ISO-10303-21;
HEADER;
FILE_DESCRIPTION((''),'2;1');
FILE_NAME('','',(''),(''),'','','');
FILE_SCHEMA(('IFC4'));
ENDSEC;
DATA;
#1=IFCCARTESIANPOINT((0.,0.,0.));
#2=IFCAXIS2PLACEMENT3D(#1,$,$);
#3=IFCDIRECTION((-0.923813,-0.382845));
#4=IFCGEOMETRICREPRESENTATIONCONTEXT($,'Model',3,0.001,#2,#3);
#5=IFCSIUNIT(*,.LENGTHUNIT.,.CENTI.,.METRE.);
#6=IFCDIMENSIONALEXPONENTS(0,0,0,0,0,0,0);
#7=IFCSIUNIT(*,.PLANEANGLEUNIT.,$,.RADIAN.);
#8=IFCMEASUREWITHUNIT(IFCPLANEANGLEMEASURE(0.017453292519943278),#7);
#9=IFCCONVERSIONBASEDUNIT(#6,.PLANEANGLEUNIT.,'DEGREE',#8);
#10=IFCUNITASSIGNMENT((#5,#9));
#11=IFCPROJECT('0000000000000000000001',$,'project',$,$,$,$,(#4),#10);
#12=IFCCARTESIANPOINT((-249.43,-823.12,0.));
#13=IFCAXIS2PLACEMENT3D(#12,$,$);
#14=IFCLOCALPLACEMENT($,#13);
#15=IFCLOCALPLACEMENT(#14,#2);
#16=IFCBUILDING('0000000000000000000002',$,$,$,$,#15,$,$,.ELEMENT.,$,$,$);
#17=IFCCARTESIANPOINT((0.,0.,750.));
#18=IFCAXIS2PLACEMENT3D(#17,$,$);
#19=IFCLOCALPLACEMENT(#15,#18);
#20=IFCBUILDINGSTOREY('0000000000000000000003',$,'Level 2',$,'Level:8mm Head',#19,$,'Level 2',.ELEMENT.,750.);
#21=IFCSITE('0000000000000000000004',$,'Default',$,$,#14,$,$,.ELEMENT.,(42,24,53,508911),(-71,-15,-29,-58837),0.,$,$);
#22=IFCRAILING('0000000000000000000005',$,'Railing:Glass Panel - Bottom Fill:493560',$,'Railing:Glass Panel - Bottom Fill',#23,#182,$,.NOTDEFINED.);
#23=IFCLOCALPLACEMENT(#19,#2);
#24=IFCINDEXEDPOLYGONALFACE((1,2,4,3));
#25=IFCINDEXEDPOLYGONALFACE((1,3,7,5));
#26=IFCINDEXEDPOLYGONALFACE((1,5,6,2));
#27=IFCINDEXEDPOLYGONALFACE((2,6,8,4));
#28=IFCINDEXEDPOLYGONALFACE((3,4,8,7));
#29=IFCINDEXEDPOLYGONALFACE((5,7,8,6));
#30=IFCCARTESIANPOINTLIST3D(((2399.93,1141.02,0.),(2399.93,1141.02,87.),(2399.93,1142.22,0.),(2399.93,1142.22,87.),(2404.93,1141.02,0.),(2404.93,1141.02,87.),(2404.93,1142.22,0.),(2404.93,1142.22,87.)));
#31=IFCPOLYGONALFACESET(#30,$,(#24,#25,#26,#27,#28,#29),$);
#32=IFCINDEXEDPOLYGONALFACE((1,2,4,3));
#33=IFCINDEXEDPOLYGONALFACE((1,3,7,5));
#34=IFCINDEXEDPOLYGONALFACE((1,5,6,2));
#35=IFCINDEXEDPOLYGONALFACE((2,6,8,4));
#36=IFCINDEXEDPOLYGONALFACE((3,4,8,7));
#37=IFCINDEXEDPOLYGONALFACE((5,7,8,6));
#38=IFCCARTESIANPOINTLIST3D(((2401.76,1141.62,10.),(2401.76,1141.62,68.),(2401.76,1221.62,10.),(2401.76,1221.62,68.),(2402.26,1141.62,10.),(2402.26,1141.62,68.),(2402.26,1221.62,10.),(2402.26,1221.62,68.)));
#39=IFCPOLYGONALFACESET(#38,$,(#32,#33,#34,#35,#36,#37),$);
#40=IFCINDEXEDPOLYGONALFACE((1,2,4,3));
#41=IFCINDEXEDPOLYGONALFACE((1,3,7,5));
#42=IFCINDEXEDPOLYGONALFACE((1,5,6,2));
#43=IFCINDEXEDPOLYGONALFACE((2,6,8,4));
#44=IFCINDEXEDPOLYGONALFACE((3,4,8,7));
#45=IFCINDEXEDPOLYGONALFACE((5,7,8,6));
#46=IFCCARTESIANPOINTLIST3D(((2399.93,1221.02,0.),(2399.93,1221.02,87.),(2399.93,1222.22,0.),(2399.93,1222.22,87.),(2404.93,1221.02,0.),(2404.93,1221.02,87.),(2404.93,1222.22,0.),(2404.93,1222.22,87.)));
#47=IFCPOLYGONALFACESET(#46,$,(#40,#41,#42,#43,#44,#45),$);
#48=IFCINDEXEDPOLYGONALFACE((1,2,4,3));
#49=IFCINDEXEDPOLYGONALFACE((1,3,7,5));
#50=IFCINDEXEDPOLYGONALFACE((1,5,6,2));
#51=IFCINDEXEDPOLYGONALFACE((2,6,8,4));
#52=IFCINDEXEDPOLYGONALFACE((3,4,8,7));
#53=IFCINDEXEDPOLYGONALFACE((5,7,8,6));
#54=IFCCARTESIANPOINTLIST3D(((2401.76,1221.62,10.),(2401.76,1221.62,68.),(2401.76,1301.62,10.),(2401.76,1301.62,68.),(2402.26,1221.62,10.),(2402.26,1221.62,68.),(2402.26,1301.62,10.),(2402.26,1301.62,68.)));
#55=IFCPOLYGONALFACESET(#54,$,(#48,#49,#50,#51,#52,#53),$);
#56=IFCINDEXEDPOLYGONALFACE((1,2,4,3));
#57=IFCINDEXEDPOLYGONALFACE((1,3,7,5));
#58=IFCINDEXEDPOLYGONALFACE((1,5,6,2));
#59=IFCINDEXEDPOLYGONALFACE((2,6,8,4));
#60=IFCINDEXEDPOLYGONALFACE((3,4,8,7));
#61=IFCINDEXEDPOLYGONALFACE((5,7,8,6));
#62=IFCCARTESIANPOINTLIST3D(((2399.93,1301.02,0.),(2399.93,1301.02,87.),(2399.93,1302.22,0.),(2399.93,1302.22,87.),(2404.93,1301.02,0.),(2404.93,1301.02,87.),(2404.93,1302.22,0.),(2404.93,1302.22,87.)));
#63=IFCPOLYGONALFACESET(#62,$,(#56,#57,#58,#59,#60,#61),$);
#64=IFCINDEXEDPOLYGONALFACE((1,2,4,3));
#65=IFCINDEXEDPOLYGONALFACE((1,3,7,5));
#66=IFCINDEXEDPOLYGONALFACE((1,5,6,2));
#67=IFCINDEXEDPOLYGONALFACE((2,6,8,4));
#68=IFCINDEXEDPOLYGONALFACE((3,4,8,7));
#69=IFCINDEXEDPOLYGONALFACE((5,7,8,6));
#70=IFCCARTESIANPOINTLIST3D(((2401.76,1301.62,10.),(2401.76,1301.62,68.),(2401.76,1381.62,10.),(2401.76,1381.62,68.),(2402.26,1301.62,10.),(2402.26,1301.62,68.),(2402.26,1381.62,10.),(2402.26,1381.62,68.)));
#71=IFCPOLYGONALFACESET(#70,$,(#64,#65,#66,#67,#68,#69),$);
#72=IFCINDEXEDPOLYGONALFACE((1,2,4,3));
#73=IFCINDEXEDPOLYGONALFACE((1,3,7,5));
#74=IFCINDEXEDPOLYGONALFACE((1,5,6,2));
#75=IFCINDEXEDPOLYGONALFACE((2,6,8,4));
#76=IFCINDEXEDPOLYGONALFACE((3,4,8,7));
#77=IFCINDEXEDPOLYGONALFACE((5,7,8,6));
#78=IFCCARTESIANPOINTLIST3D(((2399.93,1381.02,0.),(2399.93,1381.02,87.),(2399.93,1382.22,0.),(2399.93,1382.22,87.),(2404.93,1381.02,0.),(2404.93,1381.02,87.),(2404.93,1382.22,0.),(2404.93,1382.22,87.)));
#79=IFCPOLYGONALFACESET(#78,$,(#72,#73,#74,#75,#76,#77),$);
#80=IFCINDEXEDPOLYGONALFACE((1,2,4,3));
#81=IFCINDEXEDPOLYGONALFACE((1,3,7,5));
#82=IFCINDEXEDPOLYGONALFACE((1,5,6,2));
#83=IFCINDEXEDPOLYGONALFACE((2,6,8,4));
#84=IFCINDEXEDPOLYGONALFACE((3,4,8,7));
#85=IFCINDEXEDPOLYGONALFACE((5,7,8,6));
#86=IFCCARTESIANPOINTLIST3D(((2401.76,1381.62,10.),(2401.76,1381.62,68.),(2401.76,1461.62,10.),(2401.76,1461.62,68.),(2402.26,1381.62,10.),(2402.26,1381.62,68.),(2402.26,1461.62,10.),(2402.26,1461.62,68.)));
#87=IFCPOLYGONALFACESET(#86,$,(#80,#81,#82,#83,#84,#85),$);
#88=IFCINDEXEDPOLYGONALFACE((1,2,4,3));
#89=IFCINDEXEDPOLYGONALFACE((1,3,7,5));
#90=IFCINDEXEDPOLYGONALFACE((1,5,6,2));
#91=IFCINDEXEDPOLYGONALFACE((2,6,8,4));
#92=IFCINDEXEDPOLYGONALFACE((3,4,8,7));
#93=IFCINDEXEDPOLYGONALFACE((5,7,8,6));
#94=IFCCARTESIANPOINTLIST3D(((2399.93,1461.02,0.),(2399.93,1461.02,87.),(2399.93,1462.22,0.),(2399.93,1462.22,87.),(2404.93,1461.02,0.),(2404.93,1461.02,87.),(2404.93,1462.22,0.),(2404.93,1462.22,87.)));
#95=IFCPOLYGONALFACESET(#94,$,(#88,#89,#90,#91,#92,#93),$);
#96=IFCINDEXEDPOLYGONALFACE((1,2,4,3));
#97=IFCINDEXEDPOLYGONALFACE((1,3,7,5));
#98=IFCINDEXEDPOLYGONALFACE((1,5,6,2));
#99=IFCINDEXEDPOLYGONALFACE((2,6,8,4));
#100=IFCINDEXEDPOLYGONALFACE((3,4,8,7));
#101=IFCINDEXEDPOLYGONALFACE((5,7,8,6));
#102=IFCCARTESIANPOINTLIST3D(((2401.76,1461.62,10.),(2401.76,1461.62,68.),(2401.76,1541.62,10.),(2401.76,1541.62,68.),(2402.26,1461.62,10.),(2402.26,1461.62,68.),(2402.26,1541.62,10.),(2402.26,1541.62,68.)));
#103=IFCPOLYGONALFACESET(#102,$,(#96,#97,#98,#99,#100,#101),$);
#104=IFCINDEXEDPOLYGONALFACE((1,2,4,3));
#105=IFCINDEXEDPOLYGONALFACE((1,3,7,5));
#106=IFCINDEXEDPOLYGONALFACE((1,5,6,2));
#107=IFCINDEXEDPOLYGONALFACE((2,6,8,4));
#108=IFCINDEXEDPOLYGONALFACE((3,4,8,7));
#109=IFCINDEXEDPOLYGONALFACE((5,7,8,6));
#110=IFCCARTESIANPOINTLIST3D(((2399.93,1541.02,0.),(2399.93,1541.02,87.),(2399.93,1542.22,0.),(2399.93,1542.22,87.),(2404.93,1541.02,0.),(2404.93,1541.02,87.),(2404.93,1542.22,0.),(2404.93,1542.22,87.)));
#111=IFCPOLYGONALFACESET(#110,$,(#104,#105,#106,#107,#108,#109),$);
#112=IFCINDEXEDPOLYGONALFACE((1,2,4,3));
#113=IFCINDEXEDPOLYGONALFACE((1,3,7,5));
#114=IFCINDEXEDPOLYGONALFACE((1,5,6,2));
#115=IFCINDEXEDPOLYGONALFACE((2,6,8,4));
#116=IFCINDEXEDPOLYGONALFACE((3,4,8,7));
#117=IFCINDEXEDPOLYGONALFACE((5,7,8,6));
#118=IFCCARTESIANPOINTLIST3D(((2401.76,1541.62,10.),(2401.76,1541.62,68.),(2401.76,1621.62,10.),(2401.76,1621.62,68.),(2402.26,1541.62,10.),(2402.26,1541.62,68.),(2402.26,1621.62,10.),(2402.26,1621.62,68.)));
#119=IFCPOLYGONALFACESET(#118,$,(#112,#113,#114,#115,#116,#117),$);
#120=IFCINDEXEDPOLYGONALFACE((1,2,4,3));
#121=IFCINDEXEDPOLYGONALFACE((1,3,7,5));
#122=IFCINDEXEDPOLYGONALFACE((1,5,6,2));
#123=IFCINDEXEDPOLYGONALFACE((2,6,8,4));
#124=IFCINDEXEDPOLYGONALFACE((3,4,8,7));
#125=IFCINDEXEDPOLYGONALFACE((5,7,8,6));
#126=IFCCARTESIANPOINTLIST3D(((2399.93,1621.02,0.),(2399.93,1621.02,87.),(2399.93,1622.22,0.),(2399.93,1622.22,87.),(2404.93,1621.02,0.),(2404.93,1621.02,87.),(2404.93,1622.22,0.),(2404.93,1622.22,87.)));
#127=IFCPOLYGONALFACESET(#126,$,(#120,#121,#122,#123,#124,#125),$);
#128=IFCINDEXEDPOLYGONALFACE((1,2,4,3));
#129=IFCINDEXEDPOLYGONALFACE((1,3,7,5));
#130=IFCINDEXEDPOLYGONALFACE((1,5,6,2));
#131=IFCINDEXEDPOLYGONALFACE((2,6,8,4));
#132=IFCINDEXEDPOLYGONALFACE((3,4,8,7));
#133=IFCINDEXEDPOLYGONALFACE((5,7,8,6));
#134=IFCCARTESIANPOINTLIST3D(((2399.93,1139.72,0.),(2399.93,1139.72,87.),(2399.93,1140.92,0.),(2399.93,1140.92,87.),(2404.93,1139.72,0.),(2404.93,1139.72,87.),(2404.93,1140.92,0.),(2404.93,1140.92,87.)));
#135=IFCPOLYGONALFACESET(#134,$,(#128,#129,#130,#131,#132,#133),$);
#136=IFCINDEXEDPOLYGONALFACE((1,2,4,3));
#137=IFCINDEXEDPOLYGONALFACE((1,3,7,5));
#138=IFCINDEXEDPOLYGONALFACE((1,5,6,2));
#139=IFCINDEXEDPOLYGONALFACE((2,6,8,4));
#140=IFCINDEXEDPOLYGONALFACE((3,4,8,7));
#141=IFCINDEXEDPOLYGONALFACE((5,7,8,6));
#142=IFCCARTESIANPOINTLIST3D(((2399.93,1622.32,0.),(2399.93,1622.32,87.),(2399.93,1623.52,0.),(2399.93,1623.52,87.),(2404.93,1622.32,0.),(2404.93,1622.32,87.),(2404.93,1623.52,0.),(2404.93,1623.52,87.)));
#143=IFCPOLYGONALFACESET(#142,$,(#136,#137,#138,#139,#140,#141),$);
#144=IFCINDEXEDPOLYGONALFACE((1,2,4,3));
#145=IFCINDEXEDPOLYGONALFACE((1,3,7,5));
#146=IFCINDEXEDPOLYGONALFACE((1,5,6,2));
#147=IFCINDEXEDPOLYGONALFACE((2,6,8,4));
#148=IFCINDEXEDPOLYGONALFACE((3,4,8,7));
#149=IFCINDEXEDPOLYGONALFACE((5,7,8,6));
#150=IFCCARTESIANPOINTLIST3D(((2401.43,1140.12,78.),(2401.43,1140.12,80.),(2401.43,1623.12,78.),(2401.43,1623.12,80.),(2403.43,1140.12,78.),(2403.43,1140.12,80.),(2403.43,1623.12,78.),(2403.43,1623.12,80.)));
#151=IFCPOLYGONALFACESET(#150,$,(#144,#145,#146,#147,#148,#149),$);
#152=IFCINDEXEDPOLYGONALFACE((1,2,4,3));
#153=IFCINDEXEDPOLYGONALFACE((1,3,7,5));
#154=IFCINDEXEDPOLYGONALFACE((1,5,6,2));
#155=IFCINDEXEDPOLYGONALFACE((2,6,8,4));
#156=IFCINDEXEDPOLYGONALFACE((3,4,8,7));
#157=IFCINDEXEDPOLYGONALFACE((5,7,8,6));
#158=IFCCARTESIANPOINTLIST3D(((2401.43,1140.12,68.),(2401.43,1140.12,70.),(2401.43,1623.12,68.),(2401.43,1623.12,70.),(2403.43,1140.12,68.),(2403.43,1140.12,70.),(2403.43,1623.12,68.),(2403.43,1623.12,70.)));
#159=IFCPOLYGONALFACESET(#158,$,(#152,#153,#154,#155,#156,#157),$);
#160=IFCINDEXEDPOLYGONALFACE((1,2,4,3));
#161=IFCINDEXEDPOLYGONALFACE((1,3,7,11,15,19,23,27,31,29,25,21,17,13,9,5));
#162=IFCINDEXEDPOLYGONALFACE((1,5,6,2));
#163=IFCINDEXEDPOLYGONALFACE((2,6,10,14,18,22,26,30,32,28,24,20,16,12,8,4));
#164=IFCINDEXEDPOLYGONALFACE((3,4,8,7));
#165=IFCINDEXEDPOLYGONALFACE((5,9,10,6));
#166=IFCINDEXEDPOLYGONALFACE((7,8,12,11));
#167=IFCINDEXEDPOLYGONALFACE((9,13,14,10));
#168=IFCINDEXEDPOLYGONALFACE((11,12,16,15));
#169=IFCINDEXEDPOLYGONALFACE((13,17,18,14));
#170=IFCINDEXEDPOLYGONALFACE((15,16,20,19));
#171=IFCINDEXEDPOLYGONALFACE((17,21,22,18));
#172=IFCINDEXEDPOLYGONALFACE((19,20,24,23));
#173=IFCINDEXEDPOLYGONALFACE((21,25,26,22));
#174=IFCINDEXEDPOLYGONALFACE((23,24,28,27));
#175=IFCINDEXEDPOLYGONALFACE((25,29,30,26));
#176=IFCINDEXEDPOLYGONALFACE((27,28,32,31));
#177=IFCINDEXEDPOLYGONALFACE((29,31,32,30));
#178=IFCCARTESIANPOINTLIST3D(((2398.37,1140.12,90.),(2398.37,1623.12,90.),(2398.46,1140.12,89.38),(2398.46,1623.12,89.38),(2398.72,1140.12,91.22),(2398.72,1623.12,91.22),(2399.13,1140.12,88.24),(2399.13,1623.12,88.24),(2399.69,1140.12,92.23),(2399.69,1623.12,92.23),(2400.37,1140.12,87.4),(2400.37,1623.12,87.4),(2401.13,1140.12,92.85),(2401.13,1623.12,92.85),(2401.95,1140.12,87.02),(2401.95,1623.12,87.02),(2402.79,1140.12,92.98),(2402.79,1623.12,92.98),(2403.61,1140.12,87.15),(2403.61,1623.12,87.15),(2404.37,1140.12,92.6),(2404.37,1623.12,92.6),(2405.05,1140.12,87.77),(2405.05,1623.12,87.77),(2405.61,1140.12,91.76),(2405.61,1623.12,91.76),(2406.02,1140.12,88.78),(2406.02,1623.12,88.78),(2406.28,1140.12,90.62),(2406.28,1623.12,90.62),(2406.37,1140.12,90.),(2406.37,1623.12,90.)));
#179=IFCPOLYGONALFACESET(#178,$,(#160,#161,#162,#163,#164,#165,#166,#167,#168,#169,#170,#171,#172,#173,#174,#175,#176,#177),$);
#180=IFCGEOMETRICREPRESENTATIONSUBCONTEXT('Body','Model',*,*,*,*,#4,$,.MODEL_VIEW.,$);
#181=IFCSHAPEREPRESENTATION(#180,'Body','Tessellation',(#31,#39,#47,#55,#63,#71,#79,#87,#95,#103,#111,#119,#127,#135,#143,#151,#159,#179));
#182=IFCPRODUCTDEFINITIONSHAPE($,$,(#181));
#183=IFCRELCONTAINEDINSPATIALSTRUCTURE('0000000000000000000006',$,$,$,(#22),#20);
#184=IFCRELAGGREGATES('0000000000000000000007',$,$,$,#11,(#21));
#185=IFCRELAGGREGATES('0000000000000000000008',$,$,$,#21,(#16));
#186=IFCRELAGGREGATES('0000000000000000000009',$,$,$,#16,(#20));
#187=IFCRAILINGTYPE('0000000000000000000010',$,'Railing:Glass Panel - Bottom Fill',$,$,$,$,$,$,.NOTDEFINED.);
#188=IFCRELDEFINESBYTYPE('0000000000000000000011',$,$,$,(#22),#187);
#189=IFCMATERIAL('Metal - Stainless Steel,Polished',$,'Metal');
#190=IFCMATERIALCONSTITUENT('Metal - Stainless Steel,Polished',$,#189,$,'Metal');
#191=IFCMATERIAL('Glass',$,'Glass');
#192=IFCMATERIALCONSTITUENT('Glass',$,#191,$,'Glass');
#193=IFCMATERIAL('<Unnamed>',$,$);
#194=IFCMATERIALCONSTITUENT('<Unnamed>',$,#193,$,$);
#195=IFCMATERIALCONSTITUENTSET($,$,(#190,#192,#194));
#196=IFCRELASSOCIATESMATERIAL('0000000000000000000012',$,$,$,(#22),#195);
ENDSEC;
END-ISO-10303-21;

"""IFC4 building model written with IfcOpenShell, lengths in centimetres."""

from ifc_helpers import new_model, entity, si_unit, converted_unit, direction, frame, origin, place, context, subcontext, project, spatial, indexed_curve, outline, extrude, material, constituent, constituent_set, type_object, element, save


model = new_model("IFC4")

# Units and contexts
model_context = context("Model", 3, precision=0.001, world=origin(), true_north=direction((-0.923813, -0.382845)))
body_context = subcontext(model_context, "Body", "Model", "MODEL_VIEW")
ifc_project = project(units=[si_unit("LENGTHUNIT", "METRE", prefix="CENTI"), converted_unit("PLANEANGLEUNIT", "DEGREE", entity("IfcPlaneAngleMeasure", 0.017453292519943278), si_unit("PLANEANGLEUNIT", "RADIAN"), dimensions=[0, 0, 0, 0, 0, 0, 0])], contexts=[model_context])

# Site, building, storey
site_placement = place(None, frame((-249.43, -823.12, 0.0)))
site = spatial("IfcSite", under=ifc_project, at=site_placement, Name="Default", CompositionType="ELEMENT", RefLatitude=(42, 24, 53, 508911), RefLongitude=(-71, -15, -29, -58837), RefElevation=0.0)
building_placement = place(site_placement, origin())
building = spatial("IfcBuilding", under=site, at=building_placement, CompositionType="ELEMENT")
storey_placement = place(building_placement, frame((0.0, 0.0, 750.0)))
storey = spatial("IfcBuildingStorey", under=building, at=storey_placement, Name="Level 2", ObjectType="Level:8mm Head", LongName="Level 2", CompositionType="ELEMENT", Elevation=750.0)

# Railing
ifc_material_1 = material(Name="Metal - Stainless Steel,Polished", Category="Metal")
ifc_constituent_1 = constituent(ifc_material_1, Name="Metal - Stainless Steel,Polished", Category="Metal")
ifc_material_2 = material(Name="Glass", Category="Glass")
ifc_constituent_2 = constituent(ifc_material_2, Name="Glass", Category="Glass")
ifc_material_3 = material(Name="<Unnamed>")
ifc_constituent_3 = constituent(ifc_material_3, Name="<Unnamed>")
ifc_constituent_set_1 = constituent_set(constituents=[ifc_constituent_1, ifc_constituent_2, ifc_constituent_3])
railing_type = type_object("IfcRailingType", Name="Railing:Glass Panel - Bottom Fill", PredefinedType="NOTDEFINED")
railing_placement = place(storey_placement, frame((2398.21, 1139.72, 0.0)))
element("IfcRailing", 1, at=railing_placement, inside=storey, type_object=railing_type, material=ifc_constituent_set_1, Name="Railing:Glass Panel - Bottom Fill:493560", ObjectType="Railing:Glass Panel - Bottom Fill", PredefinedType="NOTDEFINED", context=body_context, shape_type="SweptSolid", body=[
    extrude(outline(indexed_curve([(-2.5, -0.6), (2.5, -0.6), (2.5, 0.6), (-2.5, 0.6), (-2.5, -0.6)], self_intersect=False)), frame((4.22, 1.9, 0.0), z_axis=(0.0, 0.0, 1.0), x_axis=(-1.0, 0.0, 0.0)), (0.0, 0.0, 1.0), 87.0),
    extrude(outline(indexed_curve([(-0.25, -40.0), (0.25, -40.0), (0.25, 40.0), (-0.25, 40.0), (-0.25, -40.0)], self_intersect=False)), frame((3.8, 41.9, 10.0), z_axis=(0.0, 0.0, 1.0), x_axis=(-1.0, 0.0, 0.0)), (0.0, 0.0, 1.0), 58.0),
    extrude(outline(indexed_curve([(-2.5, -0.6), (2.5, -0.6), (2.5, 0.6), (-2.5, 0.6), (-2.5, -0.6)], self_intersect=False)), frame((4.22, 81.9, 0.0), z_axis=(0.0, 0.0, 1.0), x_axis=(-1.0, 0.0, 0.0)), (0.0, 0.0, 1.0), 87.0),
    extrude(outline(indexed_curve([(-0.25, -40.0), (0.25, -40.0), (0.25, 40.0), (-0.25, 40.0), (-0.25, -40.0)], self_intersect=False)), frame((3.8, 121.9, 10.0), z_axis=(0.0, 0.0, 1.0), x_axis=(-1.0, 0.0, 0.0)), (0.0, 0.0, 1.0), 58.0),
    extrude(outline(indexed_curve([(-2.5, -0.6), (2.5, -0.6), (2.5, 0.6), (-2.5, 0.6), (-2.5, -0.6)], self_intersect=False)), frame((4.22, 161.9, 0.0), z_axis=(0.0, 0.0, 1.0), x_axis=(-1.0, 0.0, 0.0)), (0.0, 0.0, 1.0), 87.0),
    extrude(outline(indexed_curve([(-0.25, -40.0), (0.25, -40.0), (0.25, 40.0), (-0.25, 40.0), (-0.25, -40.0)], self_intersect=False)), frame((3.8, 201.9, 10.0), z_axis=(0.0, 0.0, 1.0), x_axis=(-1.0, 0.0, 0.0)), (0.0, 0.0, 1.0), 58.0),
    extrude(outline(indexed_curve([(-2.5, -0.6), (2.5, -0.6), (2.5, 0.6), (-2.5, 0.6), (-2.5, -0.6)], self_intersect=False)), frame((4.22, 241.9, 0.0), z_axis=(0.0, 0.0, 1.0), x_axis=(-1.0, 0.0, 0.0)), (0.0, 0.0, 1.0), 87.0),
    extrude(outline(indexed_curve([(-0.25, -40.0), (0.25, -40.0), (0.25, 40.0), (-0.25, 40.0), (-0.25, -40.0)], self_intersect=False)), frame((3.8, 281.9, 10.0), z_axis=(0.0, 0.0, 1.0), x_axis=(-1.0, 0.0, 0.0)), (0.0, 0.0, 1.0), 58.0),
    extrude(outline(indexed_curve([(-2.5, -0.6), (2.5, -0.6), (2.5, 0.6), (-2.5, 0.6), (-2.5, -0.6)], self_intersect=False)), frame((4.22, 321.9, 0.0), z_axis=(0.0, 0.0, 1.0), x_axis=(-1.0, 0.0, 0.0)), (0.0, 0.0, 1.0), 87.0),
    extrude(outline(indexed_curve([(-0.25, -40.0), (0.25, -40.0), (0.25, 40.0), (-0.25, 40.0), (-0.25, -40.0)], self_intersect=False)), frame((3.8, 361.9, 10.0), z_axis=(0.0, 0.0, 1.0), x_axis=(-1.0, 0.0, 0.0)), (0.0, 0.0, 1.0), 58.0),
    extrude(outline(indexed_curve([(-2.5, -0.6), (2.5, -0.6), (2.5, 0.6), (-2.5, 0.6), (-2.5, -0.6)], self_intersect=False)), frame((4.22, 401.9, 0.0), z_axis=(0.0, 0.0, 1.0), x_axis=(-1.0, 0.0, 0.0)), (0.0, 0.0, 1.0), 87.0),
    extrude(outline(indexed_curve([(-0.25, -40.0), (0.25, -40.0), (0.25, 40.0), (-0.25, 40.0), (-0.25, -40.0)], self_intersect=False)), frame((3.8, 441.9, 10.0), z_axis=(0.0, 0.0, 1.0), x_axis=(-1.0, 0.0, 0.0)), (0.0, 0.0, 1.0), 58.0),
    extrude(outline(indexed_curve([(-2.5, -0.6), (2.5, -0.6), (2.5, 0.6), (-2.5, 0.6), (-2.5, -0.6)], self_intersect=False)), frame((4.22, 481.9, 0.0), z_axis=(0.0, 0.0, 1.0), x_axis=(-1.0, 0.0, 0.0)), (0.0, 0.0, 1.0), 87.0),
    extrude(outline(indexed_curve([(-2.5, -0.6), (2.5, -0.6), (2.5, 0.6), (-2.5, 0.6), (-2.5, -0.6)], self_intersect=False)), frame((4.22, 0.6, 0.0), z_axis=(0.0, 0.0, 1.0), x_axis=(-1.0, 0.0, 0.0)), (0.0, 0.0, 1.0), 87.0),
    extrude(outline(indexed_curve([(-2.5, -0.6), (2.5, -0.6), (2.5, 0.6), (-2.5, 0.6), (-2.5, -0.6)], self_intersect=False)), frame((4.22, 483.2, 0.0), z_axis=(0.0, 0.0, 1.0), x_axis=(-1.0, 0.0, 0.0)), (0.0, 0.0, 1.0), 87.0),
    extrude(outline(indexed_curve([(-241.5, -1.0), (241.5, -1.0), (241.5, 1.0), (-241.5, 1.0), (-241.5, -1.0)], self_intersect=False)), frame((4.22, 241.9, 78.0), z_axis=(0.0, 0.0, 1.0), x_axis=(0.0, -1.0, 0.0)), (0.0, 0.0, 1.0), 2.0),
    extrude(outline(indexed_curve([(-241.5, -1.0), (241.5, -1.0), (241.5, 1.0), (-241.5, 1.0), (-241.5, -1.0)], self_intersect=False)), frame((4.22, 241.9, 68.0), z_axis=(0.0, 0.0, 1.0), x_axis=(0.0, -1.0, 0.0)), (0.0, 0.0, 1.0), 2.0),
    extrude(outline(indexed_curve([(-1.09, -3.85), (0.18, -3.85), (1.42, -3.18), (2.41, -1.97), (2.98, -0.41), (3.04, 1.22), (2.58, 2.63), (1.67, 3.59), (1.09, 3.85), (-0.18, 3.85), (-1.42, 3.18), (-2.41, 1.97), (-2.98, 0.41), (-3.04, -1.22), (-2.58, -2.63), (-1.67, -3.59), (-1.09, -3.85)], self_intersect=False)), frame((4.16, 0.4, 90.0), z_axis=(0.0, 1.0, 0.0), x_axis=(-0.27267, 0.0, -0.962108)), (0.0, 0.0, 1.0), 483.0),
])

save(model, "model.ifc")
